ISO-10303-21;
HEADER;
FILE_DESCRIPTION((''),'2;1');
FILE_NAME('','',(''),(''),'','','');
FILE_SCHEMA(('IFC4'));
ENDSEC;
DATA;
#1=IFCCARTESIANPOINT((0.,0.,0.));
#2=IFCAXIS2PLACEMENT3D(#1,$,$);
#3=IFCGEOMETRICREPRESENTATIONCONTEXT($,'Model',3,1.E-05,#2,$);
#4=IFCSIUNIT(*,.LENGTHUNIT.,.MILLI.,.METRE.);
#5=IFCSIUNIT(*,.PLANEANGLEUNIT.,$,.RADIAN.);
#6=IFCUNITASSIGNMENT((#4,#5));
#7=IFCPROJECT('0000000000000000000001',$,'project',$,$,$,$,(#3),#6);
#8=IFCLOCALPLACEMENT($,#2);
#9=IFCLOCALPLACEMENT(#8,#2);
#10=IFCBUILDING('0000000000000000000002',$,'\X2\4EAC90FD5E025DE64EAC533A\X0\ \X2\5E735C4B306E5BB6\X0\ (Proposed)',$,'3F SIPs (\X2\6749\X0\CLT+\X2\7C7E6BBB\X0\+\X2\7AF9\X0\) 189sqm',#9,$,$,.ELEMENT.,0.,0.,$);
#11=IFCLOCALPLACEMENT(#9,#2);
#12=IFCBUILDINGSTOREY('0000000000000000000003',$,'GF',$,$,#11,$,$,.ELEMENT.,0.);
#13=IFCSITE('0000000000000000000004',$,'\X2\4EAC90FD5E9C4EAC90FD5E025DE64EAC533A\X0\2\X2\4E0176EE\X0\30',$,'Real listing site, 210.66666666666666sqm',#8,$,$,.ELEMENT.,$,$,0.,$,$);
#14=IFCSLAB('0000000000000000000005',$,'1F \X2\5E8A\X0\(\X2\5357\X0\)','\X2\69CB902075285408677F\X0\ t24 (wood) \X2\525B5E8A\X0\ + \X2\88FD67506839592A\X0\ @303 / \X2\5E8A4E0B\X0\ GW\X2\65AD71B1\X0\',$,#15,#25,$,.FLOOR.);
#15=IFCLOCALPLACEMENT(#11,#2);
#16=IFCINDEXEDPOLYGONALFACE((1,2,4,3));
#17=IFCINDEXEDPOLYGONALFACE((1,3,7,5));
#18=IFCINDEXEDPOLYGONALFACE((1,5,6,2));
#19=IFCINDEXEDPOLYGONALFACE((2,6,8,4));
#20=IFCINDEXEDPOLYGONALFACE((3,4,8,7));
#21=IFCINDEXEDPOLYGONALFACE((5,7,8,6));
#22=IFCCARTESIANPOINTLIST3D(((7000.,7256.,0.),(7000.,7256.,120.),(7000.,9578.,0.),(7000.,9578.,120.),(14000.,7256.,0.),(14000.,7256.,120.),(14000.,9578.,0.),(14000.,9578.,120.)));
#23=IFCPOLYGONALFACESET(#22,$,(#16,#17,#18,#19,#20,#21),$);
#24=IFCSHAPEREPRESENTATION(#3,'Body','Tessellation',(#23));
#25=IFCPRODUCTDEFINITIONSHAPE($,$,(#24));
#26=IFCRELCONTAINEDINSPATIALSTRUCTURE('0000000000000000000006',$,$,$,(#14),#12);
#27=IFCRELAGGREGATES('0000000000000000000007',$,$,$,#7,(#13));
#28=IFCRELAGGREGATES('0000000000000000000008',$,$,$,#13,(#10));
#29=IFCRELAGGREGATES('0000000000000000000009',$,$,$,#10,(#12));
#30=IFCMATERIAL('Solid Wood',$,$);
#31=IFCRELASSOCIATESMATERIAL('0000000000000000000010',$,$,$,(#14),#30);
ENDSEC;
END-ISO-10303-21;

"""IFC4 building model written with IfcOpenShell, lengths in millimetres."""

from ifc_helpers import new_model, si_unit, frame, frame_2d, origin, place, context, project, spatial, rectangle, extrude, material, element, save


model = new_model("IFC4")

# Units and contexts
model_context = context("Model", 3, precision=1e-05, world=origin())
ifc_project = project(units=[si_unit("LENGTHUNIT", "METRE", prefix="MILLI"), si_unit("PLANEANGLEUNIT", "RADIAN")], contexts=[model_context])

# Site, building, storey
site_placement = place(None, origin())
site = spatial("IfcSite", under=ifc_project, at=site_placement, Name="京都府京都市左京区2丁目30", ObjectType="Real listing site, 210.66666666666666sqm", CompositionType="ELEMENT", RefElevation=0.0)
building_placement = place(site_placement, origin())
building = spatial("IfcBuilding", under=site, at=building_placement, Name="京都市左京区 平屋の家 (Proposed)", ObjectType="3F SIPs (杉CLT+籾殻+竹) 189sqm", CompositionType="ELEMENT", ElevationOfRefHeight=0.0, ElevationOfTerrain=0.0)
storey_placement = place(building_placement, origin())
storey = spatial("IfcBuildingStorey", under=building, at=storey_placement, Name="GF", CompositionType="ELEMENT", Elevation=0.0)

# Slab
ifc_material_1 = material(Name="Solid Wood")
slab_1_placement = place(storey_placement, frame((3500.0, 3628.0, 0.0)))
element("IfcSlab", 1, at=slab_1_placement, inside=storey, material=ifc_material_1, Name="1F 床(南)", Description="構造用合板 t24 (wood) 剛床 + 製材根太 @303 / 床下 GW断熱", PredefinedType="FLOOR", context=model_context, shape_type="SweptSolid", body=[
    extrude(rectangle(XDim=7000.0, YDim=2322.0, at=frame_2d((3500.0, 1161.0))), frame((3500.0, 3628.0, 0.0)), (0.0, 0.0, 1.0), 120.0),
])

save(model, "model.ifc")
